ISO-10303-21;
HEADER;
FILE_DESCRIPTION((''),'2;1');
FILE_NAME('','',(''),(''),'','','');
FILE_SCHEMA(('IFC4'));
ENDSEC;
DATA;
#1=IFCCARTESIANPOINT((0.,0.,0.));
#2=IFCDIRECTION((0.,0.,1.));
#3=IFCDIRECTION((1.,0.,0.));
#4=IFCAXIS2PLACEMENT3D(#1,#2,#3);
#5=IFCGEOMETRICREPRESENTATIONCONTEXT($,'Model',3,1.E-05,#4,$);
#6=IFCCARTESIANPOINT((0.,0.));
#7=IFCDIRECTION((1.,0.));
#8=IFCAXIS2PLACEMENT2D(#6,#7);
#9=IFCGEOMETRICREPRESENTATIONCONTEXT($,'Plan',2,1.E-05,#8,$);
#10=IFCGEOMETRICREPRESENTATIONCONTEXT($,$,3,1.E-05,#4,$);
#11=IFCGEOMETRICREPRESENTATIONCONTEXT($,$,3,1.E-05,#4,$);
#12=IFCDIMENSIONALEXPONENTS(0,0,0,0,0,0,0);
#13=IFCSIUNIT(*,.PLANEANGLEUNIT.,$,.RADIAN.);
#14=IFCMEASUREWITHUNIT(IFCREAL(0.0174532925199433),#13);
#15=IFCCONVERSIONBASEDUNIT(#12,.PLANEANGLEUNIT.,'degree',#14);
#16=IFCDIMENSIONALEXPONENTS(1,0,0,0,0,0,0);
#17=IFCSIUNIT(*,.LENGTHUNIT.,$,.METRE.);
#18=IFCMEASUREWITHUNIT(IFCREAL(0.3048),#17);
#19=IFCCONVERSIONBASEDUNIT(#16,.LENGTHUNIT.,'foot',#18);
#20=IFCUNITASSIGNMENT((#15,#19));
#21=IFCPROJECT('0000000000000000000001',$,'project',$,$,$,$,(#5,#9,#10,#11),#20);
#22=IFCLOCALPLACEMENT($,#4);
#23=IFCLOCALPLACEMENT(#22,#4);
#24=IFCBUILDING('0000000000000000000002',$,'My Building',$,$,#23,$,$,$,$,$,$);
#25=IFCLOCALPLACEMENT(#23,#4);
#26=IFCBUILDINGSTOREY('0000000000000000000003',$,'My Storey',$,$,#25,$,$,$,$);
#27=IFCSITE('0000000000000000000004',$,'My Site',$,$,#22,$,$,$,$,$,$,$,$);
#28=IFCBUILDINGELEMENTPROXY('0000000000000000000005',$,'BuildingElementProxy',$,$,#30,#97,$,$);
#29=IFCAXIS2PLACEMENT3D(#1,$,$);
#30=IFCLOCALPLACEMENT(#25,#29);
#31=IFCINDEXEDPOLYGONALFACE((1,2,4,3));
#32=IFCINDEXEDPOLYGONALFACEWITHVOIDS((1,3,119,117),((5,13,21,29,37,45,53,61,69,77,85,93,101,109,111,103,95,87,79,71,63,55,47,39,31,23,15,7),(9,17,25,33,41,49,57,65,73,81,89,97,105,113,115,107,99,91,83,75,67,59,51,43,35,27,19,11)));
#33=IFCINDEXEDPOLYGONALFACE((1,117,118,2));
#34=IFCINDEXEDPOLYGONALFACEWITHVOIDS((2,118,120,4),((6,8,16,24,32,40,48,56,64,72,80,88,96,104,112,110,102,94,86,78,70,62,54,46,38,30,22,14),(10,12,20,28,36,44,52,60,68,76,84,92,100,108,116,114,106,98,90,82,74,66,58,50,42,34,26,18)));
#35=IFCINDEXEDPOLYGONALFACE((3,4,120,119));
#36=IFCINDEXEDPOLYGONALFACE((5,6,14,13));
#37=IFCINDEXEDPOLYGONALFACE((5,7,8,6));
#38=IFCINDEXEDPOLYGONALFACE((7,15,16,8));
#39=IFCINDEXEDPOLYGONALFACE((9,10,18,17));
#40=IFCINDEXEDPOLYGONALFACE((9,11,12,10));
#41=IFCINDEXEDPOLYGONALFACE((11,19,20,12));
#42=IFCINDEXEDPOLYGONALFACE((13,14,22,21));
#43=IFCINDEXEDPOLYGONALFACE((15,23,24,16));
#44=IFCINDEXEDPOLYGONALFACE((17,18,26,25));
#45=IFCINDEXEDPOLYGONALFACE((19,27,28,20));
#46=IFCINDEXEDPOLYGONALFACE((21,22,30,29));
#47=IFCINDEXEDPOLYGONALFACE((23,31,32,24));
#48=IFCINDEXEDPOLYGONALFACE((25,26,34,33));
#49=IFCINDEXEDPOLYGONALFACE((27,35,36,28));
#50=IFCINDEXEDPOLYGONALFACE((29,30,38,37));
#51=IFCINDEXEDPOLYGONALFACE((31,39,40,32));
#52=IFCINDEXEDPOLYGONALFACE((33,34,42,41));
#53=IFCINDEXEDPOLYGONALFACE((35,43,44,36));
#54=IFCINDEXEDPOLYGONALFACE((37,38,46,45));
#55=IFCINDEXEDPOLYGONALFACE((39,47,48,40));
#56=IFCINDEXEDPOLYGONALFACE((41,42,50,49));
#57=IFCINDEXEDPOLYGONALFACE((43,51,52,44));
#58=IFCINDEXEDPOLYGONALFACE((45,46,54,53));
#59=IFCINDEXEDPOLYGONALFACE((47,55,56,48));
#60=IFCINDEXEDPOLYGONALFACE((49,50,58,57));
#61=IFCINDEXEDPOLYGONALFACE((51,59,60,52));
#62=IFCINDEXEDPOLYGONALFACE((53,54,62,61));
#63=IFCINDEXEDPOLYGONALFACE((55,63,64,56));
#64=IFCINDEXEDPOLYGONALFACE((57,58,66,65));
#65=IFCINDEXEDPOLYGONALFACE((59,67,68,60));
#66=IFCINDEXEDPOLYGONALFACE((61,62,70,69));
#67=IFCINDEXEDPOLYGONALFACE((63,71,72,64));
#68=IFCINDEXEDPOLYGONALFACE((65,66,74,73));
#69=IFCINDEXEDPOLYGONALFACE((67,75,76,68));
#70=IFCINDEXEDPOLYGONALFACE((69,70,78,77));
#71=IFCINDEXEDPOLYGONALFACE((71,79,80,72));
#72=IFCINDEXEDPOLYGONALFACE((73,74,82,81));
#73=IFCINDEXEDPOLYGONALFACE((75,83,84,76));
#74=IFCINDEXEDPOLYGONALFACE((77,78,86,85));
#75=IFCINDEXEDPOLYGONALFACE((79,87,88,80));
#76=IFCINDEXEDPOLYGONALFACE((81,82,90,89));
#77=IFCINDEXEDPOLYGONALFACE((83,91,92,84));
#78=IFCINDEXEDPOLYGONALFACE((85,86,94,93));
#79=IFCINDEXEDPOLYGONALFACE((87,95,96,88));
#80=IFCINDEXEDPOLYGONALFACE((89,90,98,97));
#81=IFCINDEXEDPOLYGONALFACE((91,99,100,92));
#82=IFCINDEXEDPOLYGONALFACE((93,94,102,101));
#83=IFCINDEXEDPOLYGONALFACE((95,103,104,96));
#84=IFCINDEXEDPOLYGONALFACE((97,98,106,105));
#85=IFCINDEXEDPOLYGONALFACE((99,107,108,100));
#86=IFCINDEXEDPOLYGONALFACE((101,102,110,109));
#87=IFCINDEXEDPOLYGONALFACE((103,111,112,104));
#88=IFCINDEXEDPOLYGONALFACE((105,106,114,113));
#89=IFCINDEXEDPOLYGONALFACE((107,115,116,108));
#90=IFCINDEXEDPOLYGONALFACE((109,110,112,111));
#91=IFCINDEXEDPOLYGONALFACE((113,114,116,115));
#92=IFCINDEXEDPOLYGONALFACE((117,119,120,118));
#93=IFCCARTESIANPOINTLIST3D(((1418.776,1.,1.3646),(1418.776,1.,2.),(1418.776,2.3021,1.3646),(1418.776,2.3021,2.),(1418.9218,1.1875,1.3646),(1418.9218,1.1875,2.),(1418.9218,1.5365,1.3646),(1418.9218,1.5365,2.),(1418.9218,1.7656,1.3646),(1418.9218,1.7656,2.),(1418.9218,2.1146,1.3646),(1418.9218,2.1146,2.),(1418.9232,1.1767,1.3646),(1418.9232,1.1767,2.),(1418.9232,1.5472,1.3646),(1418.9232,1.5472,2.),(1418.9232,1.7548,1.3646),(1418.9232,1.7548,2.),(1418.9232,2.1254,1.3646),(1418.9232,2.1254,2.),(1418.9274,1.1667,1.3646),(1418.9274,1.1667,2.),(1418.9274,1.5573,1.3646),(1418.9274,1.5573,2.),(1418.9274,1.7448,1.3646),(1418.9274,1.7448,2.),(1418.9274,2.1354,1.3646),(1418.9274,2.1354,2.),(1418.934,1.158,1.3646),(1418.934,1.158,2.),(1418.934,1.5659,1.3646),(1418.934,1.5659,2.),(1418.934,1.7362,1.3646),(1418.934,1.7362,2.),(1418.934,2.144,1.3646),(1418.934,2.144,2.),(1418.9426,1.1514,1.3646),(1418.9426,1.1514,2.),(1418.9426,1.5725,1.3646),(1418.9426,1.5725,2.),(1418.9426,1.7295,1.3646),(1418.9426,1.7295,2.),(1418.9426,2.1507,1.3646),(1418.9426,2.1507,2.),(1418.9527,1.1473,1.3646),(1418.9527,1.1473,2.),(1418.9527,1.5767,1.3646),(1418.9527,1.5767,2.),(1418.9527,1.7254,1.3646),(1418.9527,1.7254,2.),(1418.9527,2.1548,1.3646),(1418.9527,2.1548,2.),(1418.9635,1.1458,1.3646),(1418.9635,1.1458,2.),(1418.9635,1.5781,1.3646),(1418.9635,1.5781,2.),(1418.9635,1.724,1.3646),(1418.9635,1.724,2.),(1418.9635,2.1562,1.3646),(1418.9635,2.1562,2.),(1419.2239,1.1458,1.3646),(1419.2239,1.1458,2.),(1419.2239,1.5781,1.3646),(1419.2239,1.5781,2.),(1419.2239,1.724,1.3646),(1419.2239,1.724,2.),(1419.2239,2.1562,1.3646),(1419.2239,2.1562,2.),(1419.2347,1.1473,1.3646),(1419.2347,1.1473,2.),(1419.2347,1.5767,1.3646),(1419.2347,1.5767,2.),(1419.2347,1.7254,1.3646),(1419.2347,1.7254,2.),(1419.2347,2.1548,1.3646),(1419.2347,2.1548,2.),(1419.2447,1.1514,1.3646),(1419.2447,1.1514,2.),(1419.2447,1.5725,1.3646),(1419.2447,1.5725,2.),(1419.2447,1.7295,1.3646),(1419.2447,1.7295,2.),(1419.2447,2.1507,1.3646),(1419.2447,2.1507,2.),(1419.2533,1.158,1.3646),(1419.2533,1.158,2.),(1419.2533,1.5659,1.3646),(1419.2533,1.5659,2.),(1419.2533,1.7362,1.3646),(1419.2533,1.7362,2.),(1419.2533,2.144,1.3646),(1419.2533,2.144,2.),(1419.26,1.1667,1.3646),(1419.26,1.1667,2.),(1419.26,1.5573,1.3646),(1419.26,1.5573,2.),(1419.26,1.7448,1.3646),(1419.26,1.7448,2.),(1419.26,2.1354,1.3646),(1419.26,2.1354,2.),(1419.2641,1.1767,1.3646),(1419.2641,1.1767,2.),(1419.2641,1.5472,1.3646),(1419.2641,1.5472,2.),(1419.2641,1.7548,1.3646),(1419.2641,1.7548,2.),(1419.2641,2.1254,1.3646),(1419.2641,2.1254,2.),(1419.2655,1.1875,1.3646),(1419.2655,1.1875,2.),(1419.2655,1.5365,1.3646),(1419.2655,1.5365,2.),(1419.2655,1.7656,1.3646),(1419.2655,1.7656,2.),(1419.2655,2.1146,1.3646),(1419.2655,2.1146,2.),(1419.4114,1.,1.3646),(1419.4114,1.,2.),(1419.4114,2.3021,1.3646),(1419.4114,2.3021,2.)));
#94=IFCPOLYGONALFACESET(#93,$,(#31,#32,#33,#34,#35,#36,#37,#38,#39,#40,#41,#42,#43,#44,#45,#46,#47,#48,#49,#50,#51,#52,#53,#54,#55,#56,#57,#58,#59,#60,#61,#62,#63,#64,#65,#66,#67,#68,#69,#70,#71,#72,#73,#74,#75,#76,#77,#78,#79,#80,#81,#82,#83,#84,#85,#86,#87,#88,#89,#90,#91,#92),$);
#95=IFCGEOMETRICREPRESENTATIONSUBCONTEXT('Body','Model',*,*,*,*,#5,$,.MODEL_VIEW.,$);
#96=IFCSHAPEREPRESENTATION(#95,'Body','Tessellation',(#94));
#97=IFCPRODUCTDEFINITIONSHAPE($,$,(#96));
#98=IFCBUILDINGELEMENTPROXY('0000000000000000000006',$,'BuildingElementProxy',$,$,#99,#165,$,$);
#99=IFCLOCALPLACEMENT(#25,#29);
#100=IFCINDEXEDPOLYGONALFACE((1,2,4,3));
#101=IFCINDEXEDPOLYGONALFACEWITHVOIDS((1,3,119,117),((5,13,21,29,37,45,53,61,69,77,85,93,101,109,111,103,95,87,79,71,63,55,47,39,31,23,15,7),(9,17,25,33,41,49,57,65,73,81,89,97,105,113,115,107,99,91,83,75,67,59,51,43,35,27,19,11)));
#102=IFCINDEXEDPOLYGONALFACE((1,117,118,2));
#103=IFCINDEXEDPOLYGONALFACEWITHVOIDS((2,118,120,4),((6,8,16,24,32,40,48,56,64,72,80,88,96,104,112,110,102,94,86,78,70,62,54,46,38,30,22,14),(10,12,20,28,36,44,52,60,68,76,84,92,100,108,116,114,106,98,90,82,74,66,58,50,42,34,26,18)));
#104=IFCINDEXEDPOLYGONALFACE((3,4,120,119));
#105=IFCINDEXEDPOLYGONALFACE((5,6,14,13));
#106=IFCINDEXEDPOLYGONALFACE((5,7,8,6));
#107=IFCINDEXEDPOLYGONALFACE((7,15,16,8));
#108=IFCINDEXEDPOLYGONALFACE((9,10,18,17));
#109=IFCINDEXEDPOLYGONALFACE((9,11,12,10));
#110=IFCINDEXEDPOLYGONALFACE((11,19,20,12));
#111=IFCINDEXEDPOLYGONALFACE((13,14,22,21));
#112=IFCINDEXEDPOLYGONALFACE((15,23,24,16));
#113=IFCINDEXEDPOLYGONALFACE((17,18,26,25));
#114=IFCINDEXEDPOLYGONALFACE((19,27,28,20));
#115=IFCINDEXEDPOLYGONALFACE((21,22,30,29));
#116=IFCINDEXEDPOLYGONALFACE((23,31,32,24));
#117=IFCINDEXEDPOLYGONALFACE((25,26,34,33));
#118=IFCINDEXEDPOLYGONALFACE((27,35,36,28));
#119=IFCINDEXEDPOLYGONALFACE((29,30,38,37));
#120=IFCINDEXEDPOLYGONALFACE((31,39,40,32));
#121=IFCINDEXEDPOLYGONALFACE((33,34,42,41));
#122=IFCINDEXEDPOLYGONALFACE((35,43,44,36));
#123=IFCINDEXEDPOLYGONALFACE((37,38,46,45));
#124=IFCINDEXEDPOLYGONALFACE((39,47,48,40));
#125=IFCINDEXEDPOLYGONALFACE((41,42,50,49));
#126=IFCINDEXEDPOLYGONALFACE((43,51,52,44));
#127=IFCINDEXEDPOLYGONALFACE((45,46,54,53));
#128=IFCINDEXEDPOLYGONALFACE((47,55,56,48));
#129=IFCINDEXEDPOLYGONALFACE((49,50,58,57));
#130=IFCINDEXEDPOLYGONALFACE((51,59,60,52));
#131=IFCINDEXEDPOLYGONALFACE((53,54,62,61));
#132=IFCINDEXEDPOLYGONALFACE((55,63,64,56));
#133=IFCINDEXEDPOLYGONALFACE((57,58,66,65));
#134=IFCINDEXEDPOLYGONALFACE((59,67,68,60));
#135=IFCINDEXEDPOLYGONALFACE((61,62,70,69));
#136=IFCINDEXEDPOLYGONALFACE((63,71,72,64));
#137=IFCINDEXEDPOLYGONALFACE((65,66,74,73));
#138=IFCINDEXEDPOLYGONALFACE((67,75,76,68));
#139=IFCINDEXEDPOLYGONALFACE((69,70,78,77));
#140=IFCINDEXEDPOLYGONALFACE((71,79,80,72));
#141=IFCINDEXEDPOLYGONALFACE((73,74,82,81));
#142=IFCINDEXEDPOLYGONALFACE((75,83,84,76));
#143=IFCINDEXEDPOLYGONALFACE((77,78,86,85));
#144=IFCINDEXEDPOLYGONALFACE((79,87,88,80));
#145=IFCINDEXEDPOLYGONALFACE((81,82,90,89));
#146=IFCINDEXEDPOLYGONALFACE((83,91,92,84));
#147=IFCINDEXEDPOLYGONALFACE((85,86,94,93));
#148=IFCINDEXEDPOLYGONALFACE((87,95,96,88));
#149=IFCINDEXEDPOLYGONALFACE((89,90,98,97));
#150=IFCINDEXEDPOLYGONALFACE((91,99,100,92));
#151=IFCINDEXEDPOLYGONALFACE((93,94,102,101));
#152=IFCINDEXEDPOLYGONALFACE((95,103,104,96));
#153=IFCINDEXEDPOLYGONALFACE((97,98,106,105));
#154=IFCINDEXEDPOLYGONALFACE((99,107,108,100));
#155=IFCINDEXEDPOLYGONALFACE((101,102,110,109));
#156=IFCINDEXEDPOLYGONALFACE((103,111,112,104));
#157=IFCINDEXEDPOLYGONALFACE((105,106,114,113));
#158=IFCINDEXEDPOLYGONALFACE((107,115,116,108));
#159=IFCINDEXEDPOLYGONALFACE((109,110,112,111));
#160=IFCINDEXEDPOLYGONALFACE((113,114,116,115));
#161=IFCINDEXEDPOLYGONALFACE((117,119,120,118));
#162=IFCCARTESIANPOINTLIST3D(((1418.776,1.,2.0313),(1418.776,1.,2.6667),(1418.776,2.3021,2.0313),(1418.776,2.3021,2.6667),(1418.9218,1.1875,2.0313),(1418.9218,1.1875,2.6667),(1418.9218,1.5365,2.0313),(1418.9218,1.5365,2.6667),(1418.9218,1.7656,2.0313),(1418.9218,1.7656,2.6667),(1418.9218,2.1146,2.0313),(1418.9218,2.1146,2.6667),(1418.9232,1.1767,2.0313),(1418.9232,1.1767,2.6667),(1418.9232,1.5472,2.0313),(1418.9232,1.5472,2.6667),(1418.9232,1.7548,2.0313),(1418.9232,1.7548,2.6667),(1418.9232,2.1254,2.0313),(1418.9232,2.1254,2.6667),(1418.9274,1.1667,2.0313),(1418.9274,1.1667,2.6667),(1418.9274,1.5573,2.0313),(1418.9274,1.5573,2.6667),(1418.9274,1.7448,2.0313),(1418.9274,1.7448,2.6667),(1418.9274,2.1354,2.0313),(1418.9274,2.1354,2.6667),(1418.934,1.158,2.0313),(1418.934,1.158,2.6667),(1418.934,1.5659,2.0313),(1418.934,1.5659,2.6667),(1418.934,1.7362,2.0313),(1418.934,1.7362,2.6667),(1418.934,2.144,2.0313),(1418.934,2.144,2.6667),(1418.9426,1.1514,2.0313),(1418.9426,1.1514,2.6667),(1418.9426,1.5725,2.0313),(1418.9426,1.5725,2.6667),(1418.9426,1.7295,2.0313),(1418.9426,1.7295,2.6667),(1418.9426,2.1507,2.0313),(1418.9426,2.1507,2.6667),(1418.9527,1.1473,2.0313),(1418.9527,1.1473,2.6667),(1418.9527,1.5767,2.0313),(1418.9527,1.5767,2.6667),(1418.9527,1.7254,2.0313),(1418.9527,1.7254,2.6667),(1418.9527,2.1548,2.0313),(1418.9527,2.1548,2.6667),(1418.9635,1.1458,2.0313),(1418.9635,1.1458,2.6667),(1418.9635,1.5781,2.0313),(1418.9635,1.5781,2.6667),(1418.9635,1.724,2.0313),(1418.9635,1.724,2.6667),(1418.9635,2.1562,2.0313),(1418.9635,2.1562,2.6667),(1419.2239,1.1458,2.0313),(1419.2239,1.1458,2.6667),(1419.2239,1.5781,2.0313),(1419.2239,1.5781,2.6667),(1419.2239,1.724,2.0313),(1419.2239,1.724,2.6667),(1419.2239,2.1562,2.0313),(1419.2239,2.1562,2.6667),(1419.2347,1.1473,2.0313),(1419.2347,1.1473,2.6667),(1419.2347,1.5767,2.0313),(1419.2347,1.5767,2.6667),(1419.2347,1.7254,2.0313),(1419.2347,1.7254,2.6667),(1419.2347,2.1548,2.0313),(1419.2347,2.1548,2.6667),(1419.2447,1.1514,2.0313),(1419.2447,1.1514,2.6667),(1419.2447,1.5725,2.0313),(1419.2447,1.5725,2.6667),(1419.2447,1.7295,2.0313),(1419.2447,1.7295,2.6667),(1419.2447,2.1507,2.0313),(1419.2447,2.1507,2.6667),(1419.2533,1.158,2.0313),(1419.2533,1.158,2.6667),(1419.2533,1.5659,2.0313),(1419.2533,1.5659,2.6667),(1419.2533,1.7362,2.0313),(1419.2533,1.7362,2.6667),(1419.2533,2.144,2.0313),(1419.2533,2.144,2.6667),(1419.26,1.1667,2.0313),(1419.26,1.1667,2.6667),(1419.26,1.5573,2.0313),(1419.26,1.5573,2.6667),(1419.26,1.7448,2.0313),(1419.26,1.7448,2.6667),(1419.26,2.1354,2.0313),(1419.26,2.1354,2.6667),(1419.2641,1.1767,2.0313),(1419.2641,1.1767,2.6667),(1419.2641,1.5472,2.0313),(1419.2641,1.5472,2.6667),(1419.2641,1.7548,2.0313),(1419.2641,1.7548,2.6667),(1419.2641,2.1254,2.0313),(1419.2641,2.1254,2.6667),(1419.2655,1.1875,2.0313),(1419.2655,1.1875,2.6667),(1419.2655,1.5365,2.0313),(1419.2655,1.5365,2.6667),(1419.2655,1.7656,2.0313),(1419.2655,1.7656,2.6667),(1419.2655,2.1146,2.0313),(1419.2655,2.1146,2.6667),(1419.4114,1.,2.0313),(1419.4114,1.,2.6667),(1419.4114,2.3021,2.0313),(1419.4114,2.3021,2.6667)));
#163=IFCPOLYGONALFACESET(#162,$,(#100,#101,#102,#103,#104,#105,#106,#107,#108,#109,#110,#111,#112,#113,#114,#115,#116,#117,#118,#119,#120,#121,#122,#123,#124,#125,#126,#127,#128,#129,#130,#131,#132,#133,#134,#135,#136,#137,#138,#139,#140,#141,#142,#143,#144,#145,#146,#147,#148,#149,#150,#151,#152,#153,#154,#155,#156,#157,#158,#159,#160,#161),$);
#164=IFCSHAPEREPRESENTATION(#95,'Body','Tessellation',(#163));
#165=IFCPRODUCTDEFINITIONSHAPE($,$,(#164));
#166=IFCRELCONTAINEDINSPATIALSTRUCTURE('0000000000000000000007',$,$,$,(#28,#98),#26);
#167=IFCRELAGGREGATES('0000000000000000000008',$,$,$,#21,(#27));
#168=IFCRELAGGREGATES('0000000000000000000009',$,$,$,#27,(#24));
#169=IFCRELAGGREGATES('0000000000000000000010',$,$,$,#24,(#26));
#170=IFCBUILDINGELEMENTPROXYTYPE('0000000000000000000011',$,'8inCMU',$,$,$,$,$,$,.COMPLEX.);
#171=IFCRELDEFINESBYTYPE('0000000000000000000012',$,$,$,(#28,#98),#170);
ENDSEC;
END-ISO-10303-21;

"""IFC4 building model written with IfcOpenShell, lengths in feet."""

from ifc_helpers import new_model, entity, si_unit, converted_unit, frame, origin_with_axes, origin_2d_with_axis, place, context, subcontext, project, spatial, line, indexed_curve, outline, extrude, source, transform, mapped, type_object, type_shapes, element, save


model = new_model("IFC4")

# Units and contexts
model_context_1 = context("Model", 3, precision=1e-05, world=origin_with_axes())
plan_context = context("Plan", 2, precision=1e-05, world=origin_2d_with_axis())
context_of_model_1 = context(None, 3, precision=1e-05, world=origin_with_axes())
context_of_model_2 = context(None, 3, precision=1e-05, world=origin_with_axes())
body_context_1 = subcontext(model_context_1, "Body", "Model", "MODEL_VIEW")
ifc_project = project(units=[converted_unit("PLANEANGLEUNIT", "degree", entity("IfcReal", 0.0174532925199433), si_unit("PLANEANGLEUNIT", "RADIAN"), dimensions=[0, 0, 0, 0, 0, 0, 0]), converted_unit("LENGTHUNIT", "foot", entity("IfcReal", 0.3048), si_unit("LENGTHUNIT", "METRE"), dimensions=[1, 0, 0, 0, 0, 0, 0])], contexts=[model_context_1, plan_context, context_of_model_1, context_of_model_2])

# Site, building, storey
site_placement = place(None, origin_with_axes())
site = spatial("IfcSite", under=ifc_project, at=site_placement, Name="My Site")
building_placement = place(site_placement, origin_with_axes())
building = spatial("IfcBuilding", under=site, at=building_placement, Name="My Building")
storey_placement = place(building_placement, origin_with_axes())
storey = spatial("IfcBuildingStorey", under=building, at=storey_placement, Name="My Storey")

# Building element proxies
building_element_proxy_type_1 = type_object("IfcBuildingElementProxyType", Name="8inCMU", PredefinedType="COMPLEX")
shared_shape_1 = source(origin_with_axes(), body_context_1, "Body", "SweptSolid", [
    extrude(outline(indexed_curve([(-0.3177, -0.651), (0.3177, -0.651), (0.3177, 0.651), (-0.3177, 0.651), (0.1719, -0.1146), (0.1719, -0.4635), (0.1705, -0.4743), (0.1663, -0.4844), (0.1597, -0.493), (0.151, -0.4996), (0.141, -0.5038), (0.1302, -0.5052), (-0.1302, -0.5052), (-0.141, -0.5038), (-0.151, -0.4996), (-0.1597, -0.493), (-0.1663, -0.4844), (-0.1705, -0.4743), (-0.1719, -0.4635), (-0.1719, -0.1146), (-0.1705, -0.1038), (-0.1663, -0.0938), (-0.1597, -0.0851), (-0.151, -0.0785), (-0.141, -0.0743), (-0.1302, -0.0729), (0.1302, -0.0729), (0.141, -0.0743), (0.151, -0.0785), (0.1597, -0.0851), (0.1663, -0.0938), (0.1705, -0.1038), (0.151, 0.0785), (0.141, 0.0743), (0.1302, 0.0729), (-0.1302, 0.0729), (-0.141, 0.0743), (-0.151, 0.0785), (-0.1597, 0.0851), (-0.1663, 0.0937), (-0.1705, 0.1038), (-0.1719, 0.1146), (-0.1719, 0.4635), (-0.1705, 0.4743), (-0.1663, 0.4844), (-0.1597, 0.493), (-0.151, 0.4996), (-0.141, 0.5038), (-0.1302, 0.5052), (0.1302, 0.5052), (0.141, 0.5038), (0.151, 0.4996), (0.1597, 0.493), (0.1663, 0.4844), (0.1705, 0.4743), (0.1719, 0.4635), (0.1719, 0.1146), (0.1705, 0.1038), (0.1663, 0.0937), (0.1597, 0.0851)], segments=[line(4, 3), line(3, 2), line(2, 1), line(1, 4)], self_intersect=False), holes=[indexed_curve([(-0.3177, -0.651), (0.3177, -0.651), (0.3177, 0.651), (-0.3177, 0.651), (0.1719, -0.1146), (0.1719, -0.4635), (0.1705, -0.4743), (0.1663, -0.4844), (0.1597, -0.493), (0.151, -0.4996), (0.141, -0.5038), (0.1302, -0.5052), (-0.1302, -0.5052), (-0.141, -0.5038), (-0.151, -0.4996), (-0.1597, -0.493), (-0.1663, -0.4844), (-0.1705, -0.4743), (-0.1719, -0.4635), (-0.1719, -0.1146), (-0.1705, -0.1038), (-0.1663, -0.0938), (-0.1597, -0.0851), (-0.151, -0.0785), (-0.141, -0.0743), (-0.1302, -0.0729), (0.1302, -0.0729), (0.141, -0.0743), (0.151, -0.0785), (0.1597, -0.0851), (0.1663, -0.0938), (0.1705, -0.1038), (0.151, 0.0785), (0.141, 0.0743), (0.1302, 0.0729), (-0.1302, 0.0729), (-0.141, 0.0743), (-0.151, 0.0785), (-0.1597, 0.0851), (-0.1663, 0.0937), (-0.1705, 0.1038), (-0.1719, 0.1146), (-0.1719, 0.4635), (-0.1705, 0.4743), (-0.1663, 0.4844), (-0.1597, 0.493), (-0.151, 0.4996), (-0.141, 0.5038), (-0.1302, 0.5052), (0.1302, 0.5052), (0.141, 0.5038), (0.151, 0.4996), (0.1597, 0.493), (0.1663, 0.4844), (0.1705, 0.4743), (0.1719, 0.4635), (0.1719, 0.1146), (0.1705, 0.1038), (0.1663, 0.0937), (0.1597, 0.0851)], segments=[line(20, 19), line(19, 18), line(18, 17), line(17, 16), line(16, 15), line(15, 14), line(14, 13), line(13, 12), line(12, 11), line(11, 10), line(10, 9), line(9, 8), line(8, 7), line(7, 6), line(6, 5), line(5, 32), line(32, 31), line(31, 30), line(30, 29), line(29, 28), line(28, 27), line(27, 26), line(26, 25), line(25, 24), line(24, 23), line(23, 22), line(22, 21), line(21, 20)], self_intersect=False), indexed_curve([(-0.3177, -0.651), (0.3177, -0.651), (0.3177, 0.651), (-0.3177, 0.651), (0.1719, -0.1146), (0.1719, -0.4635), (0.1705, -0.4743), (0.1663, -0.4844), (0.1597, -0.493), (0.151, -0.4996), (0.141, -0.5038), (0.1302, -0.5052), (-0.1302, -0.5052), (-0.141, -0.5038), (-0.151, -0.4996), (-0.1597, -0.493), (-0.1663, -0.4844), (-0.1705, -0.4743), (-0.1719, -0.4635), (-0.1719, -0.1146), (-0.1705, -0.1038), (-0.1663, -0.0938), (-0.1597, -0.0851), (-0.151, -0.0785), (-0.141, -0.0743), (-0.1302, -0.0729), (0.1302, -0.0729), (0.141, -0.0743), (0.151, -0.0785), (0.1597, -0.0851), (0.1663, -0.0938), (0.1705, -0.1038), (0.151, 0.0785), (0.141, 0.0743), (0.1302, 0.0729), (-0.1302, 0.0729), (-0.141, 0.0743), (-0.151, 0.0785), (-0.1597, 0.0851), (-0.1663, 0.0937), (-0.1705, 0.1038), (-0.1719, 0.1146), (-0.1719, 0.4635), (-0.1705, 0.4743), (-0.1663, 0.4844), (-0.1597, 0.493), (-0.151, 0.4996), (-0.141, 0.5038), (-0.1302, 0.5052), (0.1302, 0.5052), (0.141, 0.5038), (0.151, 0.4996), (0.1597, 0.493), (0.1663, 0.4844), (0.1705, 0.4743), (0.1719, 0.4635), (0.1719, 0.1146), (0.1705, 0.1038), (0.1663, 0.0937), (0.1597, 0.0851)], segments=[line(44, 43), line(43, 42), line(42, 41), line(41, 40), line(40, 39), line(39, 38), line(38, 37), line(37, 36), line(36, 35), line(35, 34), line(34, 33), line(33, 60), line(60, 59), line(59, 58), line(58, 57), line(57, 56), line(56, 55), line(55, 54), line(54, 53), line(53, 52), line(52, 51), line(51, 50), line(50, 49), line(49, 48), line(48, 47), line(47, 46), line(46, 45), line(45, 44)], self_intersect=False)]), frame((-0.651, 0.0, 0.0), z_axis=(0.0, 0.0, 1.0), x_axis=(0.0, -1.0, 0.0)), (0.0, 0.0, 1.0), 0.6354),
])
type_shapes(building_element_proxy_type_1, [shared_shape_1])
for number, where, z_axis, x_axis, name in (
    (1, (1419.0936, 2.3021, 1.3646), (0.0, 0.0, 1.0), (0.0, 1.0, 0.0), "BuildingElementProxy"),
    (2, (1419.0936, 2.3021, 2.0313), (0.0, 0.0, 1.0), (0.0, 1.0, 0.0), "BuildingElementProxy"),
):
    element("IfcBuildingElementProxy", number, at=place(storey_placement, frame(where, z_axis=z_axis, x_axis=x_axis)), inside=storey, type_object=building_element_proxy_type_1, Name=name, context=body_context_1, shape_type="MappedRepresentation", body=[
        mapped(shared_shape_1, transform((0.0, 0.0, 0.0), x_axis=(1.0, 0.0, 0.0), y_axis=(0.0, 1.0, 0.0), z_axis=(0.0, 0.0, 1.0), scale=1.0)),
    ])

save(model, "model.ifc")
